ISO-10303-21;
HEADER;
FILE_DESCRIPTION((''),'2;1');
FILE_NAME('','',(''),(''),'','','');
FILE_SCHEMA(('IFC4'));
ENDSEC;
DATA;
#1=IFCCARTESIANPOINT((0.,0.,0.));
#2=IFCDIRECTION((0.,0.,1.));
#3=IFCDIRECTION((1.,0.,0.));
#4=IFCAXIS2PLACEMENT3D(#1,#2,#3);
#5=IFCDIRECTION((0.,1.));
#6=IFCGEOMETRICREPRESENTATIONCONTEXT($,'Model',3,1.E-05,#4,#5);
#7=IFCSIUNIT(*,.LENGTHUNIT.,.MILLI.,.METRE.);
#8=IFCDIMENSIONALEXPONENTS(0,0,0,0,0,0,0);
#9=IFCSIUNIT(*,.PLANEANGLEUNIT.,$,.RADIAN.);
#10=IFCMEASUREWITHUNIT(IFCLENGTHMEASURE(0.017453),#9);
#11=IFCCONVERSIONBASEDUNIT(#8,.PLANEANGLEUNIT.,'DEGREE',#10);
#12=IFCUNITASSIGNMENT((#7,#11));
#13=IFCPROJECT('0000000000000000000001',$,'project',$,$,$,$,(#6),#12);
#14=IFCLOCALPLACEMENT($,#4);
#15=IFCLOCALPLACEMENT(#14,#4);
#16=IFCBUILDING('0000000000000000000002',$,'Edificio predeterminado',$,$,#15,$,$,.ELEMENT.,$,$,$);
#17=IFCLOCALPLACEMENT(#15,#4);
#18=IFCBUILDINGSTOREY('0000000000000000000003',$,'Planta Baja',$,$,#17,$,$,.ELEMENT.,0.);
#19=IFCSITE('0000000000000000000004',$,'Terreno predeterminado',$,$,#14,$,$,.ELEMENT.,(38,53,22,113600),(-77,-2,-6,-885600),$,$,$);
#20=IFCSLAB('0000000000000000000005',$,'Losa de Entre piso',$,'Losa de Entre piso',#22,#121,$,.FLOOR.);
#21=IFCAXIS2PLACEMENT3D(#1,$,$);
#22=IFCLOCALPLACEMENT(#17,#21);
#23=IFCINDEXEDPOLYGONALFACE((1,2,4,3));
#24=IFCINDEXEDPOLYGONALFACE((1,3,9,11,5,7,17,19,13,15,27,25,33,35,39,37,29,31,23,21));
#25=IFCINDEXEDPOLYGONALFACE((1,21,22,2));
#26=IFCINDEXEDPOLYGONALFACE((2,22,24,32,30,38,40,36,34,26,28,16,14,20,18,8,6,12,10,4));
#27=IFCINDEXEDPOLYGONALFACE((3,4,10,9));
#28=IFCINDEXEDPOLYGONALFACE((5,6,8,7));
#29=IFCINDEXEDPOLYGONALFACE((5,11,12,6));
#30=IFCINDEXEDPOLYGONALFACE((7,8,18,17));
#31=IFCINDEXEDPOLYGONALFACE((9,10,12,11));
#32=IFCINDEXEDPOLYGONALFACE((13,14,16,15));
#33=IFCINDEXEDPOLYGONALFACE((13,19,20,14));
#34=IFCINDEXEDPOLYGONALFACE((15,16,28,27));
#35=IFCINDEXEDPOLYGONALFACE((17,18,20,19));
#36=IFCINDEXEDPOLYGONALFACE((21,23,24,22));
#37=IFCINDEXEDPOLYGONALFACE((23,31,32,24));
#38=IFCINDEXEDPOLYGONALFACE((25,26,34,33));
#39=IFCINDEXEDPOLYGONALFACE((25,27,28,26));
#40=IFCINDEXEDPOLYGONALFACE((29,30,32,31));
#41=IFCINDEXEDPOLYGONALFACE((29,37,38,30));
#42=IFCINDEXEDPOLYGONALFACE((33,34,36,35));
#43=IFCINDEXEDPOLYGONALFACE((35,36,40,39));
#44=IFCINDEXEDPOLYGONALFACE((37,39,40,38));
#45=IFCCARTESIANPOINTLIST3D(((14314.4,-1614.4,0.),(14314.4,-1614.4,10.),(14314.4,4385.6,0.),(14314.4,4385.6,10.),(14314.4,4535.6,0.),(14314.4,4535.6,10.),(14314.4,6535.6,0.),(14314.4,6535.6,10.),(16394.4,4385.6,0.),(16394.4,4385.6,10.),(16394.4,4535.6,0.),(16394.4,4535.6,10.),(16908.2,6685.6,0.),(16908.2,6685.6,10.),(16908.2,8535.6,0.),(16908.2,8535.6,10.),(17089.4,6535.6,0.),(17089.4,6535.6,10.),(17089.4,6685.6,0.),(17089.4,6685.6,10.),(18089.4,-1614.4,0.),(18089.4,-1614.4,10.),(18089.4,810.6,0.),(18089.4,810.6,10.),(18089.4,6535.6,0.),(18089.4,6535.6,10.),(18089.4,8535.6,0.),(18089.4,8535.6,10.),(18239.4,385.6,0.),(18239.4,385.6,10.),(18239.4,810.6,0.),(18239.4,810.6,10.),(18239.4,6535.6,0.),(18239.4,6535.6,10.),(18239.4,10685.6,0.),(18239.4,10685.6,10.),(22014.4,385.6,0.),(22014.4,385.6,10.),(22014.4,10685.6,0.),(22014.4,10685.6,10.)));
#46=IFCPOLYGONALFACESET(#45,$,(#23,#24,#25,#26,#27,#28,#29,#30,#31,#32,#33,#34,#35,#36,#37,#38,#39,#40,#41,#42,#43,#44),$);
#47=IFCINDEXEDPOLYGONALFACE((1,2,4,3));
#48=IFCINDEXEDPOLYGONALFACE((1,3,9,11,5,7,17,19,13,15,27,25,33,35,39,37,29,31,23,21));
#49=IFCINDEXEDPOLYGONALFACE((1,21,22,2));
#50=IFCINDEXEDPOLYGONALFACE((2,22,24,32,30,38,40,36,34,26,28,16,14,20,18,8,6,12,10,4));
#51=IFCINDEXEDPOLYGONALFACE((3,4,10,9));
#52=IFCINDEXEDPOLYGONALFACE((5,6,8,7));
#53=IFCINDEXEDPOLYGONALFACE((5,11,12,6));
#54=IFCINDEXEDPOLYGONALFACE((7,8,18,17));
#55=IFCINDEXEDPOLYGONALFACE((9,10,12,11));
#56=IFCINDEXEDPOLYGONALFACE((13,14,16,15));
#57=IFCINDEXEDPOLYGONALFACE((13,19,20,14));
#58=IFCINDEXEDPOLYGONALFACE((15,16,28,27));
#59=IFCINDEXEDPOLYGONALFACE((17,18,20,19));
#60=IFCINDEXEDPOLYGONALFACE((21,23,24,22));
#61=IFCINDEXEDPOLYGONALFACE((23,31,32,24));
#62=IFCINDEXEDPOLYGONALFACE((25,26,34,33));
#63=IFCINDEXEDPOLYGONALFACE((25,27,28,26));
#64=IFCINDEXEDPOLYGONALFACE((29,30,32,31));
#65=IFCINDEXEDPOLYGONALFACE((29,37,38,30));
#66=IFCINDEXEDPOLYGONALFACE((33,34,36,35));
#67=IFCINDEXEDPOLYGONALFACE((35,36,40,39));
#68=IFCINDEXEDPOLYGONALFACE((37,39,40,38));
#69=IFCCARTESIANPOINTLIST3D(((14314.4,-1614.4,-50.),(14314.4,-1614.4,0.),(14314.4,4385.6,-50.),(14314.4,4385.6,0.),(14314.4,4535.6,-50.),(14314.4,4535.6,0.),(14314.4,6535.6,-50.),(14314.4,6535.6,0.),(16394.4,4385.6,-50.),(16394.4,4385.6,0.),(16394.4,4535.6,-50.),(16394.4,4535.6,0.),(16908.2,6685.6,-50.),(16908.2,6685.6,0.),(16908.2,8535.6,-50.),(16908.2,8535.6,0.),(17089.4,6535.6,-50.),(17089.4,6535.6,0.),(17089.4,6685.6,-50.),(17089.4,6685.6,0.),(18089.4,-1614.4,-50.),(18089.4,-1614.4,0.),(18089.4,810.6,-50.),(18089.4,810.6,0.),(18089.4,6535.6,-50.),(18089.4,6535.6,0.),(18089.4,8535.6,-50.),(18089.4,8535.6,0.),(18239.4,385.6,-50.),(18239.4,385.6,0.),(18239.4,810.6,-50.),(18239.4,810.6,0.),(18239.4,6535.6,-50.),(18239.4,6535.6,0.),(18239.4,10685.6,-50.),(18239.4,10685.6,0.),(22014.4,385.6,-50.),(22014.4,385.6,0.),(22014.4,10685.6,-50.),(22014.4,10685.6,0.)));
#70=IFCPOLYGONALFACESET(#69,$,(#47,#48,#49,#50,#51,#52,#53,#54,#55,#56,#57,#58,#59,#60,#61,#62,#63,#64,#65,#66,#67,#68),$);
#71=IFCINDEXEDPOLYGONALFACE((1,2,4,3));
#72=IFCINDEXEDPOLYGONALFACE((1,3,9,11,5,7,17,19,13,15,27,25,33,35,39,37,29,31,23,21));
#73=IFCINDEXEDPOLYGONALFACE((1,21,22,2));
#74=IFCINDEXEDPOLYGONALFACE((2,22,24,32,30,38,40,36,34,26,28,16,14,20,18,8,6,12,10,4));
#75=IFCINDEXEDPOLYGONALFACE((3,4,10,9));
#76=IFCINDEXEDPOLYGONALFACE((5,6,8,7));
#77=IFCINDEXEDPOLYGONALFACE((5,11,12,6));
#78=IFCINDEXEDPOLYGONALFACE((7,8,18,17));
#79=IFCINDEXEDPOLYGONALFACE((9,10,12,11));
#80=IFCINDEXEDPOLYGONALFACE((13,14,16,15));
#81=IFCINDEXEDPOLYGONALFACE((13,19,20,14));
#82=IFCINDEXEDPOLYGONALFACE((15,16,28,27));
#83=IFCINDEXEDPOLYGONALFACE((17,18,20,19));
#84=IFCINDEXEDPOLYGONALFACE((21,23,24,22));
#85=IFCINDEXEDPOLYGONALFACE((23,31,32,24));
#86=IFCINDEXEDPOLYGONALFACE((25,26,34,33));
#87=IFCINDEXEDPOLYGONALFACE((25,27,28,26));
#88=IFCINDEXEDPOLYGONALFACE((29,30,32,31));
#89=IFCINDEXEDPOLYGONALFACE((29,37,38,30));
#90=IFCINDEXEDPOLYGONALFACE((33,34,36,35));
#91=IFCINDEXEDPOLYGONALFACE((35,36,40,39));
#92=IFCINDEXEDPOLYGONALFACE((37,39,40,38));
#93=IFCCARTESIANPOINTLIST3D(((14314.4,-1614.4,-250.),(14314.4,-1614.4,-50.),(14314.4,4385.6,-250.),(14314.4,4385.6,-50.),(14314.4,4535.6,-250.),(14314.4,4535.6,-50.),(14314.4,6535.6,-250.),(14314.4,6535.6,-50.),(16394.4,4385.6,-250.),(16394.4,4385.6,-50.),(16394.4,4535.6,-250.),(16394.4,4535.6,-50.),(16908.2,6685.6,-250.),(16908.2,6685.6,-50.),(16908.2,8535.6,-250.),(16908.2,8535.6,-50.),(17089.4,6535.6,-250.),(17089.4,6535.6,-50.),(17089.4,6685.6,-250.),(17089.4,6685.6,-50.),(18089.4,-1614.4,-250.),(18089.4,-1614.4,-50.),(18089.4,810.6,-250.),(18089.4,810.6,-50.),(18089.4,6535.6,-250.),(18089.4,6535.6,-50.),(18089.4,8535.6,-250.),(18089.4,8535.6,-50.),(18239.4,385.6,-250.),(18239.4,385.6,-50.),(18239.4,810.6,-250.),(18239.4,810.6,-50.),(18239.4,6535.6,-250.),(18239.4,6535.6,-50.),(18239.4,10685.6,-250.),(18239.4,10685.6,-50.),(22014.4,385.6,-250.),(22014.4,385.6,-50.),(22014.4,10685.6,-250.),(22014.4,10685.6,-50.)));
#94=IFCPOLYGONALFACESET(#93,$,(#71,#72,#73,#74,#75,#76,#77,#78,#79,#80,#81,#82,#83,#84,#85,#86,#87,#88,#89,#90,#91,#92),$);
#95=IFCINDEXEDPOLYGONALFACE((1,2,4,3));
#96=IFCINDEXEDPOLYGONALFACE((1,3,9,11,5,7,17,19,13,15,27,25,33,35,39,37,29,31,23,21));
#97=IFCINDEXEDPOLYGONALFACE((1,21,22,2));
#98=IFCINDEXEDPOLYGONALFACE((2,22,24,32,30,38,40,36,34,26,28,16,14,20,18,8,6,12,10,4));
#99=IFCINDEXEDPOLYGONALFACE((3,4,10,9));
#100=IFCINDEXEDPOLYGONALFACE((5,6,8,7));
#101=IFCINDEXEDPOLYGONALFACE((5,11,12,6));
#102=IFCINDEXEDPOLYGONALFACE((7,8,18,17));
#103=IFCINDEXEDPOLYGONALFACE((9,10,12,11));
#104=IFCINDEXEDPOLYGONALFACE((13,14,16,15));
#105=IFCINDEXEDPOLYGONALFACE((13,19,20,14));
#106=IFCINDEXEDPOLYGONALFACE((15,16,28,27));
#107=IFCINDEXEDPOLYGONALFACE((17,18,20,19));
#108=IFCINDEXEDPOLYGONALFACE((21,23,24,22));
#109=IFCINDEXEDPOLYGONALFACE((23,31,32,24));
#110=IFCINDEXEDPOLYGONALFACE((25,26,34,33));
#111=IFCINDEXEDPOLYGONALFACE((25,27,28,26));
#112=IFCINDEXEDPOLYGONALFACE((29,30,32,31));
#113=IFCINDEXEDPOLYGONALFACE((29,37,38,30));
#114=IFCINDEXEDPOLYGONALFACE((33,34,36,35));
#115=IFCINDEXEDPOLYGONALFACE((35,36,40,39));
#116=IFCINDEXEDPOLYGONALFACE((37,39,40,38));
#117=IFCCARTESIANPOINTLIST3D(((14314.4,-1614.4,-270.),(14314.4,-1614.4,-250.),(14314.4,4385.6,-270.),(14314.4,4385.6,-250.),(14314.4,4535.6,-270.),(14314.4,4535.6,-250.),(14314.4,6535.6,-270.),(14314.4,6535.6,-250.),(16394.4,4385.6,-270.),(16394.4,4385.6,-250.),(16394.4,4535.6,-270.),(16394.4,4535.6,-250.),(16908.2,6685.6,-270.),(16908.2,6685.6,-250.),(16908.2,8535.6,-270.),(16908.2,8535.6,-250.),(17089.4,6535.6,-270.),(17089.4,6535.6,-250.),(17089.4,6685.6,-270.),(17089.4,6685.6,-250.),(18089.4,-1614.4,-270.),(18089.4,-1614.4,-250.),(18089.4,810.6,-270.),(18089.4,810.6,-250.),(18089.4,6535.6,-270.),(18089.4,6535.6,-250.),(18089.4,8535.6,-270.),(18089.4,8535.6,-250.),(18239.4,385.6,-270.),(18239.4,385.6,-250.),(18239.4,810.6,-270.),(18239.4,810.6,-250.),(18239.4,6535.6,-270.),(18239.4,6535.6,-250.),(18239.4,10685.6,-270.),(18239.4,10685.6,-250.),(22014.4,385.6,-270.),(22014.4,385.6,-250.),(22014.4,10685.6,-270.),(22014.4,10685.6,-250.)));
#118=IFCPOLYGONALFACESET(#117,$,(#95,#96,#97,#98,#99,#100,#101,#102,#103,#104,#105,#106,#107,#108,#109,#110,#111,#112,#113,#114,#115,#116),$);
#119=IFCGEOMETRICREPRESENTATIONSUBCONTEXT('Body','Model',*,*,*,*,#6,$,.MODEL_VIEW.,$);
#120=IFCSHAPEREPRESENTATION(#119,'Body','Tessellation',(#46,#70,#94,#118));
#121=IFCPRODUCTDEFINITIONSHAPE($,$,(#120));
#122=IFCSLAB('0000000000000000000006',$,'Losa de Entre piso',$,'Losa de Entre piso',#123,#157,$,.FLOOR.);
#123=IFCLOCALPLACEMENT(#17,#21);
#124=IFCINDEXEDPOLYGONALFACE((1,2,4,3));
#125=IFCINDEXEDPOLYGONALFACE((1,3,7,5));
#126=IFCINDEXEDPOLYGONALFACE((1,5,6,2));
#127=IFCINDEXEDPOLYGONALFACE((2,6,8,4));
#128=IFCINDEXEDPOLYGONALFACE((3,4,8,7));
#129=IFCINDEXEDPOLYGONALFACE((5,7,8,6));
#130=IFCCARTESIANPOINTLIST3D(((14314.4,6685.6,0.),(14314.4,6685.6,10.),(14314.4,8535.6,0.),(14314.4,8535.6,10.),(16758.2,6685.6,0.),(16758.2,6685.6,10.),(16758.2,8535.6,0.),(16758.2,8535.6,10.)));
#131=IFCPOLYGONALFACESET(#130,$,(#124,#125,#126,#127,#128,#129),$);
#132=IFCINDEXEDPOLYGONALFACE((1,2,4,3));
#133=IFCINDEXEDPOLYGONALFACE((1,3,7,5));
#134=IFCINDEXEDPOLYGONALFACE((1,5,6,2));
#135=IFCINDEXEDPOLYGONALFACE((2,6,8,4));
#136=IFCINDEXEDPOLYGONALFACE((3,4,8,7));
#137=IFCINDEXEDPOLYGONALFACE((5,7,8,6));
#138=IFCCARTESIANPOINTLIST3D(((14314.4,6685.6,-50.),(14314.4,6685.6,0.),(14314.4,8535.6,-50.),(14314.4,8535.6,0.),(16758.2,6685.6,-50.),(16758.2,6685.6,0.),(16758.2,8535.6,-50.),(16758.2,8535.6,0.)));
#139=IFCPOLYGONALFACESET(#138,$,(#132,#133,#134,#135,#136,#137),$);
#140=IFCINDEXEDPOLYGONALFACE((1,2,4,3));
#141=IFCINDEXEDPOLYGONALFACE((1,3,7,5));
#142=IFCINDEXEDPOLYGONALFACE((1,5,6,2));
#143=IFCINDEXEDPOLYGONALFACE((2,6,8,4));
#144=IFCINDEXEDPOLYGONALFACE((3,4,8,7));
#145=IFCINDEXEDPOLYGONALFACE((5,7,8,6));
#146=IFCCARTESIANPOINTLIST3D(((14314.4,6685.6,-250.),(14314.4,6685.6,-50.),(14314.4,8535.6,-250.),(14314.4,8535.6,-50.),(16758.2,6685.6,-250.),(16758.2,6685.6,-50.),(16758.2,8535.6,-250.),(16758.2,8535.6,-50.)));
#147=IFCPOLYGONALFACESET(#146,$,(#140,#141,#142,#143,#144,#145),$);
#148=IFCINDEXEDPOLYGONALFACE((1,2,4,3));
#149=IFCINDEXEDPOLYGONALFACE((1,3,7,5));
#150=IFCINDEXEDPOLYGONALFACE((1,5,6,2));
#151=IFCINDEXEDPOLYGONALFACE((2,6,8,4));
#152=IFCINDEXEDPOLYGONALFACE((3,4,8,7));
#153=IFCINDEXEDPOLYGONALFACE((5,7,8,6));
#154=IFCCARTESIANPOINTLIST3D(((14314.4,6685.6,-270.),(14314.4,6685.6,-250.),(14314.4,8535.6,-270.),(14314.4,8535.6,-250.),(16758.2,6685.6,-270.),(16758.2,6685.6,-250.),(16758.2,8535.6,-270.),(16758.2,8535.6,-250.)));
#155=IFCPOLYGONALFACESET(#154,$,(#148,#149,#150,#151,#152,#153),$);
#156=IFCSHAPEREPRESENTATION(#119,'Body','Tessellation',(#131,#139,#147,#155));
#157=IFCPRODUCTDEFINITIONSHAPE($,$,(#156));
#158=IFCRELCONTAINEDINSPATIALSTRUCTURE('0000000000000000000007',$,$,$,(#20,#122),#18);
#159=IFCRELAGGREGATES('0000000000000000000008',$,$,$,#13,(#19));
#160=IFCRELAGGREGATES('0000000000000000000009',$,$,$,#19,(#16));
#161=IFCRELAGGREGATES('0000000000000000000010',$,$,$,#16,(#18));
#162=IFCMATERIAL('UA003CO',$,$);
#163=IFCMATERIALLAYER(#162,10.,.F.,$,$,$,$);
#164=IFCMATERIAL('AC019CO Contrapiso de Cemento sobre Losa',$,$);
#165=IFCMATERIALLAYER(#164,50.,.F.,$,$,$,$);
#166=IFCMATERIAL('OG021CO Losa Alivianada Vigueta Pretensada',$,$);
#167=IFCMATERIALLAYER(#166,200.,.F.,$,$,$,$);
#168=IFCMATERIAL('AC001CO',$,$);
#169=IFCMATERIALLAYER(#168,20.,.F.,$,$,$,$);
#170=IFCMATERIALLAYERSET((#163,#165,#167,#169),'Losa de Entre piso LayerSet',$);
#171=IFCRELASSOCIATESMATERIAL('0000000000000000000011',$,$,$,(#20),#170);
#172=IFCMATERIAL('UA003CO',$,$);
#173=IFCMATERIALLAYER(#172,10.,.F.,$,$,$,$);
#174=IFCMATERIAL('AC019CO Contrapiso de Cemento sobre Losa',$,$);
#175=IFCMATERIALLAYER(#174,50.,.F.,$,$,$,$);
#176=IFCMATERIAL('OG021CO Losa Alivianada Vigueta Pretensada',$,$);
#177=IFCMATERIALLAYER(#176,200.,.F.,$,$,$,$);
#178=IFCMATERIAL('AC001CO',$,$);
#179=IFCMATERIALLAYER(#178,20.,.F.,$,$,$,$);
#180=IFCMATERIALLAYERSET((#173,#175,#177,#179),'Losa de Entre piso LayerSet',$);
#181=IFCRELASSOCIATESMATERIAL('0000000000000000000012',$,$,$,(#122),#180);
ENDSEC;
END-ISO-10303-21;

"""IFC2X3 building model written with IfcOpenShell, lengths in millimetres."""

from ifc_helpers import new_model, entity, si_unit, converted_unit, direction, frame, origin_with_axes, place, context, subcontext, project, spatial, polyline, outline, extrude, material, layer, layer_set, layer_usage, element, save


model = new_model("IFC2X3")

# Units and contexts
model_context = context("Model", 3, precision=1e-05, world=origin_with_axes(), true_north=direction((0.0, 1.0)))
body_context = subcontext(model_context, "Body", "Model", "MODEL_VIEW")
ifc_project = project(units=[si_unit("LENGTHUNIT", "METRE", prefix="MILLI"), converted_unit("PLANEANGLEUNIT", "DEGREE", entity("IfcLengthMeasure", 0.017453), si_unit("PLANEANGLEUNIT", "RADIAN"), dimensions=[0, 0, 0, 0, 0, 0, 0])], contexts=[model_context])

# Site, building, storey
site_placement = place(None, origin_with_axes())
site = spatial("IfcSite", under=ifc_project, at=site_placement, Name="Terreno predeterminado", CompositionType="ELEMENT", RefLatitude=(38, 53, 22, 113600), RefLongitude=(-77, -2, -6, -885600))
building_placement = place(site_placement, origin_with_axes())
building = spatial("IfcBuilding", under=site, at=building_placement, Name="Edificio predeterminado", CompositionType="ELEMENT")
storey_placement = place(building_placement, origin_with_axes())
storey = spatial("IfcBuildingStorey", under=building, at=storey_placement, Name="Planta Baja", CompositionType="ELEMENT", Elevation=0.0)

# Slabs
ifc_material_1 = material(Name="UA003CO")
ifc_layer_1 = layer(ifc_material_1, 10.0, ventilated=False)
ifc_material_2 = material(Name="AC019CO Contrapiso de Cemento sobre Losa")
ifc_layer_2 = layer(ifc_material_2, 50.0, ventilated=False)
ifc_material_3 = material(Name="OG021CO Losa Alivianada Vigueta Pretensada")
ifc_layer_3 = layer(ifc_material_3, 200.0, ventilated=False)
ifc_material_4 = material(Name="AC001CO")
ifc_layer_4 = layer(ifc_material_4, 20.0, ventilated=False)
ifc_layer_set_1 = layer_set([ifc_layer_1, ifc_layer_2, ifc_layer_3, ifc_layer_4], Name="Losa de Entre piso LayerSet")
ifc_layer_usage_1 = layer_usage(ifc_layer_set_1, "AXIS3", "POSITIVE", 0.0)
slab_1_placement = place(storey_placement, origin_with_axes())
element("IfcSlab", 1, at=slab_1_placement, inside=storey, material=ifc_layer_usage_1, Name="Losa de Entre piso", ObjectType="Losa de Entre piso", PredefinedType="FLOOR", context=body_context, shape_type="SweptSolid", body=[
    extrude(outline(polyline([(0.0, -6000.0), (3775.0, -6000.0), (3775.0, -3575.0), (3925.0, -3575.0), (3925.0, -4000.0), (7700.0, -4000.0), (7700.0, 6300.0), (3925.0, 6300.0), (3925.0, 2150.0), (3775.0, 2150.0), (3775.0, 4150.0), (2593.9, 4150.0), (2593.9, 2300.0), (2775.0, 2300.0), (2775.0, 2150.0), (0.0, 2150.0), (0.0, 150.0), (2080.0, 150.0), (2080.0, 0.0), (0.0, 0.0), (0.0, -6000.0)])), frame((14314.4, 4385.6, 0.0), z_axis=(0.0, 0.0, 1.0), x_axis=(1.0, 0.0, 0.0)), (0.0, 0.0, 1.0), 10.0),
    extrude(outline(polyline([(0.0, -6000.0), (3775.0, -6000.0), (3775.0, -3575.0), (3925.0, -3575.0), (3925.0, -4000.0), (7700.0, -4000.0), (7700.0, 6300.0), (3925.0, 6300.0), (3925.0, 2150.0), (3775.0, 2150.0), (3775.0, 4150.0), (2593.9, 4150.0), (2593.9, 2300.0), (2775.0, 2300.0), (2775.0, 2150.0), (0.0, 2150.0), (0.0, 150.0), (2080.0, 150.0), (2080.0, 0.0), (0.0, 0.0), (0.0, -6000.0)])), frame((14314.4, 4385.6, -50.0), z_axis=(0.0, 0.0, 1.0), x_axis=(1.0, 0.0, 0.0)), (0.0, 0.0, 1.0), 50.0),
    extrude(outline(polyline([(0.0, -6000.0), (3775.0, -6000.0), (3775.0, -3575.0), (3925.0, -3575.0), (3925.0, -4000.0), (7700.0, -4000.0), (7700.0, 6300.0), (3925.0, 6300.0), (3925.0, 2150.0), (3775.0, 2150.0), (3775.0, 4150.0), (2593.9, 4150.0), (2593.9, 2300.0), (2775.0, 2300.0), (2775.0, 2150.0), (0.0, 2150.0), (0.0, 150.0), (2080.0, 150.0), (2080.0, 0.0), (0.0, 0.0), (0.0, -6000.0)])), frame((14314.4, 4385.6, -250.0), z_axis=(0.0, 0.0, 1.0), x_axis=(1.0, 0.0, 0.0)), (0.0, 0.0, 1.0), 200.0),
    extrude(outline(polyline([(0.0, -6000.0), (3775.0, -6000.0), (3775.0, -3575.0), (3925.0, -3575.0), (3925.0, -4000.0), (7700.0, -4000.0), (7700.0, 6300.0), (3925.0, 6300.0), (3925.0, 2150.0), (3775.0, 2150.0), (3775.0, 4150.0), (2593.9, 4150.0), (2593.9, 2300.0), (2775.0, 2300.0), (2775.0, 2150.0), (0.0, 2150.0), (0.0, 150.0), (2080.0, 150.0), (2080.0, 0.0), (0.0, 0.0), (0.0, -6000.0)])), frame((14314.4, 4385.6, -270.0), z_axis=(0.0, 0.0, 1.0), x_axis=(1.0, 0.0, 0.0)), (0.0, 0.0, 1.0), 20.0),
])
ifc_material_5 = material(Name="UA003CO")
ifc_layer_5 = layer(ifc_material_5, 10.0, ventilated=False)
ifc_material_6 = material(Name="AC019CO Contrapiso de Cemento sobre Losa")
ifc_layer_6 = layer(ifc_material_6, 50.0, ventilated=False)
ifc_material_7 = material(Name="OG021CO Losa Alivianada Vigueta Pretensada")
ifc_layer_7 = layer(ifc_material_7, 200.0, ventilated=False)
ifc_material_8 = material(Name="AC001CO")
ifc_layer_8 = layer(ifc_material_8, 20.0, ventilated=False)
ifc_layer_set_2 = layer_set([ifc_layer_5, ifc_layer_6, ifc_layer_7, ifc_layer_8], Name="Losa de Entre piso LayerSet")
ifc_layer_usage_2 = layer_usage(ifc_layer_set_2, "AXIS3", "NEGATIVE", 0.0)
slab_2_placement = place(storey_placement, origin_with_axes())
element("IfcSlab", 2, at=slab_2_placement, inside=storey, material=ifc_layer_usage_2, Name="Losa de Entre piso", ObjectType="Losa de Entre piso", PredefinedType="FLOOR", context=body_context, shape_type="SweptSolid", body=[
    extrude(outline(polyline([(0.0, 2443.9), (1850.0, 2443.9), (1850.0, 0.0), (0.0, 0.0), (0.0, 2443.9)])), frame((14314.4, 6685.6, 0.0), z_axis=(0.0, 0.0, -1.0), x_axis=(0.0, 1.0, 0.0)), (0.0, 0.0, -1.0), 10.0),
    extrude(outline(polyline([(0.0, 2443.9), (1850.0, 2443.9), (1850.0, 0.0), (0.0, 0.0), (0.0, 2443.9)])), frame((14314.4, 6685.6, -50.0), z_axis=(0.0, 0.0, -1.0), x_axis=(0.0, 1.0, 0.0)), (0.0, 0.0, -1.0), 50.0),
    extrude(outline(polyline([(0.0, 2443.9), (1850.0, 2443.9), (1850.0, 0.0), (0.0, 0.0), (0.0, 2443.9)])), frame((14314.4, 6685.6, -250.0), z_axis=(0.0, 0.0, -1.0), x_axis=(0.0, 1.0, 0.0)), (0.0, 0.0, -1.0), 200.0),
    extrude(outline(polyline([(0.0, 2443.9), (1850.0, 2443.9), (1850.0, 0.0), (0.0, 0.0), (0.0, 2443.9)])), frame((14314.4, 6685.6, -270.0), z_axis=(0.0, 0.0, -1.0), x_axis=(0.0, 1.0, 0.0)), (0.0, 0.0, -1.0), 20.0),
])

save(model, "model.ifc")
